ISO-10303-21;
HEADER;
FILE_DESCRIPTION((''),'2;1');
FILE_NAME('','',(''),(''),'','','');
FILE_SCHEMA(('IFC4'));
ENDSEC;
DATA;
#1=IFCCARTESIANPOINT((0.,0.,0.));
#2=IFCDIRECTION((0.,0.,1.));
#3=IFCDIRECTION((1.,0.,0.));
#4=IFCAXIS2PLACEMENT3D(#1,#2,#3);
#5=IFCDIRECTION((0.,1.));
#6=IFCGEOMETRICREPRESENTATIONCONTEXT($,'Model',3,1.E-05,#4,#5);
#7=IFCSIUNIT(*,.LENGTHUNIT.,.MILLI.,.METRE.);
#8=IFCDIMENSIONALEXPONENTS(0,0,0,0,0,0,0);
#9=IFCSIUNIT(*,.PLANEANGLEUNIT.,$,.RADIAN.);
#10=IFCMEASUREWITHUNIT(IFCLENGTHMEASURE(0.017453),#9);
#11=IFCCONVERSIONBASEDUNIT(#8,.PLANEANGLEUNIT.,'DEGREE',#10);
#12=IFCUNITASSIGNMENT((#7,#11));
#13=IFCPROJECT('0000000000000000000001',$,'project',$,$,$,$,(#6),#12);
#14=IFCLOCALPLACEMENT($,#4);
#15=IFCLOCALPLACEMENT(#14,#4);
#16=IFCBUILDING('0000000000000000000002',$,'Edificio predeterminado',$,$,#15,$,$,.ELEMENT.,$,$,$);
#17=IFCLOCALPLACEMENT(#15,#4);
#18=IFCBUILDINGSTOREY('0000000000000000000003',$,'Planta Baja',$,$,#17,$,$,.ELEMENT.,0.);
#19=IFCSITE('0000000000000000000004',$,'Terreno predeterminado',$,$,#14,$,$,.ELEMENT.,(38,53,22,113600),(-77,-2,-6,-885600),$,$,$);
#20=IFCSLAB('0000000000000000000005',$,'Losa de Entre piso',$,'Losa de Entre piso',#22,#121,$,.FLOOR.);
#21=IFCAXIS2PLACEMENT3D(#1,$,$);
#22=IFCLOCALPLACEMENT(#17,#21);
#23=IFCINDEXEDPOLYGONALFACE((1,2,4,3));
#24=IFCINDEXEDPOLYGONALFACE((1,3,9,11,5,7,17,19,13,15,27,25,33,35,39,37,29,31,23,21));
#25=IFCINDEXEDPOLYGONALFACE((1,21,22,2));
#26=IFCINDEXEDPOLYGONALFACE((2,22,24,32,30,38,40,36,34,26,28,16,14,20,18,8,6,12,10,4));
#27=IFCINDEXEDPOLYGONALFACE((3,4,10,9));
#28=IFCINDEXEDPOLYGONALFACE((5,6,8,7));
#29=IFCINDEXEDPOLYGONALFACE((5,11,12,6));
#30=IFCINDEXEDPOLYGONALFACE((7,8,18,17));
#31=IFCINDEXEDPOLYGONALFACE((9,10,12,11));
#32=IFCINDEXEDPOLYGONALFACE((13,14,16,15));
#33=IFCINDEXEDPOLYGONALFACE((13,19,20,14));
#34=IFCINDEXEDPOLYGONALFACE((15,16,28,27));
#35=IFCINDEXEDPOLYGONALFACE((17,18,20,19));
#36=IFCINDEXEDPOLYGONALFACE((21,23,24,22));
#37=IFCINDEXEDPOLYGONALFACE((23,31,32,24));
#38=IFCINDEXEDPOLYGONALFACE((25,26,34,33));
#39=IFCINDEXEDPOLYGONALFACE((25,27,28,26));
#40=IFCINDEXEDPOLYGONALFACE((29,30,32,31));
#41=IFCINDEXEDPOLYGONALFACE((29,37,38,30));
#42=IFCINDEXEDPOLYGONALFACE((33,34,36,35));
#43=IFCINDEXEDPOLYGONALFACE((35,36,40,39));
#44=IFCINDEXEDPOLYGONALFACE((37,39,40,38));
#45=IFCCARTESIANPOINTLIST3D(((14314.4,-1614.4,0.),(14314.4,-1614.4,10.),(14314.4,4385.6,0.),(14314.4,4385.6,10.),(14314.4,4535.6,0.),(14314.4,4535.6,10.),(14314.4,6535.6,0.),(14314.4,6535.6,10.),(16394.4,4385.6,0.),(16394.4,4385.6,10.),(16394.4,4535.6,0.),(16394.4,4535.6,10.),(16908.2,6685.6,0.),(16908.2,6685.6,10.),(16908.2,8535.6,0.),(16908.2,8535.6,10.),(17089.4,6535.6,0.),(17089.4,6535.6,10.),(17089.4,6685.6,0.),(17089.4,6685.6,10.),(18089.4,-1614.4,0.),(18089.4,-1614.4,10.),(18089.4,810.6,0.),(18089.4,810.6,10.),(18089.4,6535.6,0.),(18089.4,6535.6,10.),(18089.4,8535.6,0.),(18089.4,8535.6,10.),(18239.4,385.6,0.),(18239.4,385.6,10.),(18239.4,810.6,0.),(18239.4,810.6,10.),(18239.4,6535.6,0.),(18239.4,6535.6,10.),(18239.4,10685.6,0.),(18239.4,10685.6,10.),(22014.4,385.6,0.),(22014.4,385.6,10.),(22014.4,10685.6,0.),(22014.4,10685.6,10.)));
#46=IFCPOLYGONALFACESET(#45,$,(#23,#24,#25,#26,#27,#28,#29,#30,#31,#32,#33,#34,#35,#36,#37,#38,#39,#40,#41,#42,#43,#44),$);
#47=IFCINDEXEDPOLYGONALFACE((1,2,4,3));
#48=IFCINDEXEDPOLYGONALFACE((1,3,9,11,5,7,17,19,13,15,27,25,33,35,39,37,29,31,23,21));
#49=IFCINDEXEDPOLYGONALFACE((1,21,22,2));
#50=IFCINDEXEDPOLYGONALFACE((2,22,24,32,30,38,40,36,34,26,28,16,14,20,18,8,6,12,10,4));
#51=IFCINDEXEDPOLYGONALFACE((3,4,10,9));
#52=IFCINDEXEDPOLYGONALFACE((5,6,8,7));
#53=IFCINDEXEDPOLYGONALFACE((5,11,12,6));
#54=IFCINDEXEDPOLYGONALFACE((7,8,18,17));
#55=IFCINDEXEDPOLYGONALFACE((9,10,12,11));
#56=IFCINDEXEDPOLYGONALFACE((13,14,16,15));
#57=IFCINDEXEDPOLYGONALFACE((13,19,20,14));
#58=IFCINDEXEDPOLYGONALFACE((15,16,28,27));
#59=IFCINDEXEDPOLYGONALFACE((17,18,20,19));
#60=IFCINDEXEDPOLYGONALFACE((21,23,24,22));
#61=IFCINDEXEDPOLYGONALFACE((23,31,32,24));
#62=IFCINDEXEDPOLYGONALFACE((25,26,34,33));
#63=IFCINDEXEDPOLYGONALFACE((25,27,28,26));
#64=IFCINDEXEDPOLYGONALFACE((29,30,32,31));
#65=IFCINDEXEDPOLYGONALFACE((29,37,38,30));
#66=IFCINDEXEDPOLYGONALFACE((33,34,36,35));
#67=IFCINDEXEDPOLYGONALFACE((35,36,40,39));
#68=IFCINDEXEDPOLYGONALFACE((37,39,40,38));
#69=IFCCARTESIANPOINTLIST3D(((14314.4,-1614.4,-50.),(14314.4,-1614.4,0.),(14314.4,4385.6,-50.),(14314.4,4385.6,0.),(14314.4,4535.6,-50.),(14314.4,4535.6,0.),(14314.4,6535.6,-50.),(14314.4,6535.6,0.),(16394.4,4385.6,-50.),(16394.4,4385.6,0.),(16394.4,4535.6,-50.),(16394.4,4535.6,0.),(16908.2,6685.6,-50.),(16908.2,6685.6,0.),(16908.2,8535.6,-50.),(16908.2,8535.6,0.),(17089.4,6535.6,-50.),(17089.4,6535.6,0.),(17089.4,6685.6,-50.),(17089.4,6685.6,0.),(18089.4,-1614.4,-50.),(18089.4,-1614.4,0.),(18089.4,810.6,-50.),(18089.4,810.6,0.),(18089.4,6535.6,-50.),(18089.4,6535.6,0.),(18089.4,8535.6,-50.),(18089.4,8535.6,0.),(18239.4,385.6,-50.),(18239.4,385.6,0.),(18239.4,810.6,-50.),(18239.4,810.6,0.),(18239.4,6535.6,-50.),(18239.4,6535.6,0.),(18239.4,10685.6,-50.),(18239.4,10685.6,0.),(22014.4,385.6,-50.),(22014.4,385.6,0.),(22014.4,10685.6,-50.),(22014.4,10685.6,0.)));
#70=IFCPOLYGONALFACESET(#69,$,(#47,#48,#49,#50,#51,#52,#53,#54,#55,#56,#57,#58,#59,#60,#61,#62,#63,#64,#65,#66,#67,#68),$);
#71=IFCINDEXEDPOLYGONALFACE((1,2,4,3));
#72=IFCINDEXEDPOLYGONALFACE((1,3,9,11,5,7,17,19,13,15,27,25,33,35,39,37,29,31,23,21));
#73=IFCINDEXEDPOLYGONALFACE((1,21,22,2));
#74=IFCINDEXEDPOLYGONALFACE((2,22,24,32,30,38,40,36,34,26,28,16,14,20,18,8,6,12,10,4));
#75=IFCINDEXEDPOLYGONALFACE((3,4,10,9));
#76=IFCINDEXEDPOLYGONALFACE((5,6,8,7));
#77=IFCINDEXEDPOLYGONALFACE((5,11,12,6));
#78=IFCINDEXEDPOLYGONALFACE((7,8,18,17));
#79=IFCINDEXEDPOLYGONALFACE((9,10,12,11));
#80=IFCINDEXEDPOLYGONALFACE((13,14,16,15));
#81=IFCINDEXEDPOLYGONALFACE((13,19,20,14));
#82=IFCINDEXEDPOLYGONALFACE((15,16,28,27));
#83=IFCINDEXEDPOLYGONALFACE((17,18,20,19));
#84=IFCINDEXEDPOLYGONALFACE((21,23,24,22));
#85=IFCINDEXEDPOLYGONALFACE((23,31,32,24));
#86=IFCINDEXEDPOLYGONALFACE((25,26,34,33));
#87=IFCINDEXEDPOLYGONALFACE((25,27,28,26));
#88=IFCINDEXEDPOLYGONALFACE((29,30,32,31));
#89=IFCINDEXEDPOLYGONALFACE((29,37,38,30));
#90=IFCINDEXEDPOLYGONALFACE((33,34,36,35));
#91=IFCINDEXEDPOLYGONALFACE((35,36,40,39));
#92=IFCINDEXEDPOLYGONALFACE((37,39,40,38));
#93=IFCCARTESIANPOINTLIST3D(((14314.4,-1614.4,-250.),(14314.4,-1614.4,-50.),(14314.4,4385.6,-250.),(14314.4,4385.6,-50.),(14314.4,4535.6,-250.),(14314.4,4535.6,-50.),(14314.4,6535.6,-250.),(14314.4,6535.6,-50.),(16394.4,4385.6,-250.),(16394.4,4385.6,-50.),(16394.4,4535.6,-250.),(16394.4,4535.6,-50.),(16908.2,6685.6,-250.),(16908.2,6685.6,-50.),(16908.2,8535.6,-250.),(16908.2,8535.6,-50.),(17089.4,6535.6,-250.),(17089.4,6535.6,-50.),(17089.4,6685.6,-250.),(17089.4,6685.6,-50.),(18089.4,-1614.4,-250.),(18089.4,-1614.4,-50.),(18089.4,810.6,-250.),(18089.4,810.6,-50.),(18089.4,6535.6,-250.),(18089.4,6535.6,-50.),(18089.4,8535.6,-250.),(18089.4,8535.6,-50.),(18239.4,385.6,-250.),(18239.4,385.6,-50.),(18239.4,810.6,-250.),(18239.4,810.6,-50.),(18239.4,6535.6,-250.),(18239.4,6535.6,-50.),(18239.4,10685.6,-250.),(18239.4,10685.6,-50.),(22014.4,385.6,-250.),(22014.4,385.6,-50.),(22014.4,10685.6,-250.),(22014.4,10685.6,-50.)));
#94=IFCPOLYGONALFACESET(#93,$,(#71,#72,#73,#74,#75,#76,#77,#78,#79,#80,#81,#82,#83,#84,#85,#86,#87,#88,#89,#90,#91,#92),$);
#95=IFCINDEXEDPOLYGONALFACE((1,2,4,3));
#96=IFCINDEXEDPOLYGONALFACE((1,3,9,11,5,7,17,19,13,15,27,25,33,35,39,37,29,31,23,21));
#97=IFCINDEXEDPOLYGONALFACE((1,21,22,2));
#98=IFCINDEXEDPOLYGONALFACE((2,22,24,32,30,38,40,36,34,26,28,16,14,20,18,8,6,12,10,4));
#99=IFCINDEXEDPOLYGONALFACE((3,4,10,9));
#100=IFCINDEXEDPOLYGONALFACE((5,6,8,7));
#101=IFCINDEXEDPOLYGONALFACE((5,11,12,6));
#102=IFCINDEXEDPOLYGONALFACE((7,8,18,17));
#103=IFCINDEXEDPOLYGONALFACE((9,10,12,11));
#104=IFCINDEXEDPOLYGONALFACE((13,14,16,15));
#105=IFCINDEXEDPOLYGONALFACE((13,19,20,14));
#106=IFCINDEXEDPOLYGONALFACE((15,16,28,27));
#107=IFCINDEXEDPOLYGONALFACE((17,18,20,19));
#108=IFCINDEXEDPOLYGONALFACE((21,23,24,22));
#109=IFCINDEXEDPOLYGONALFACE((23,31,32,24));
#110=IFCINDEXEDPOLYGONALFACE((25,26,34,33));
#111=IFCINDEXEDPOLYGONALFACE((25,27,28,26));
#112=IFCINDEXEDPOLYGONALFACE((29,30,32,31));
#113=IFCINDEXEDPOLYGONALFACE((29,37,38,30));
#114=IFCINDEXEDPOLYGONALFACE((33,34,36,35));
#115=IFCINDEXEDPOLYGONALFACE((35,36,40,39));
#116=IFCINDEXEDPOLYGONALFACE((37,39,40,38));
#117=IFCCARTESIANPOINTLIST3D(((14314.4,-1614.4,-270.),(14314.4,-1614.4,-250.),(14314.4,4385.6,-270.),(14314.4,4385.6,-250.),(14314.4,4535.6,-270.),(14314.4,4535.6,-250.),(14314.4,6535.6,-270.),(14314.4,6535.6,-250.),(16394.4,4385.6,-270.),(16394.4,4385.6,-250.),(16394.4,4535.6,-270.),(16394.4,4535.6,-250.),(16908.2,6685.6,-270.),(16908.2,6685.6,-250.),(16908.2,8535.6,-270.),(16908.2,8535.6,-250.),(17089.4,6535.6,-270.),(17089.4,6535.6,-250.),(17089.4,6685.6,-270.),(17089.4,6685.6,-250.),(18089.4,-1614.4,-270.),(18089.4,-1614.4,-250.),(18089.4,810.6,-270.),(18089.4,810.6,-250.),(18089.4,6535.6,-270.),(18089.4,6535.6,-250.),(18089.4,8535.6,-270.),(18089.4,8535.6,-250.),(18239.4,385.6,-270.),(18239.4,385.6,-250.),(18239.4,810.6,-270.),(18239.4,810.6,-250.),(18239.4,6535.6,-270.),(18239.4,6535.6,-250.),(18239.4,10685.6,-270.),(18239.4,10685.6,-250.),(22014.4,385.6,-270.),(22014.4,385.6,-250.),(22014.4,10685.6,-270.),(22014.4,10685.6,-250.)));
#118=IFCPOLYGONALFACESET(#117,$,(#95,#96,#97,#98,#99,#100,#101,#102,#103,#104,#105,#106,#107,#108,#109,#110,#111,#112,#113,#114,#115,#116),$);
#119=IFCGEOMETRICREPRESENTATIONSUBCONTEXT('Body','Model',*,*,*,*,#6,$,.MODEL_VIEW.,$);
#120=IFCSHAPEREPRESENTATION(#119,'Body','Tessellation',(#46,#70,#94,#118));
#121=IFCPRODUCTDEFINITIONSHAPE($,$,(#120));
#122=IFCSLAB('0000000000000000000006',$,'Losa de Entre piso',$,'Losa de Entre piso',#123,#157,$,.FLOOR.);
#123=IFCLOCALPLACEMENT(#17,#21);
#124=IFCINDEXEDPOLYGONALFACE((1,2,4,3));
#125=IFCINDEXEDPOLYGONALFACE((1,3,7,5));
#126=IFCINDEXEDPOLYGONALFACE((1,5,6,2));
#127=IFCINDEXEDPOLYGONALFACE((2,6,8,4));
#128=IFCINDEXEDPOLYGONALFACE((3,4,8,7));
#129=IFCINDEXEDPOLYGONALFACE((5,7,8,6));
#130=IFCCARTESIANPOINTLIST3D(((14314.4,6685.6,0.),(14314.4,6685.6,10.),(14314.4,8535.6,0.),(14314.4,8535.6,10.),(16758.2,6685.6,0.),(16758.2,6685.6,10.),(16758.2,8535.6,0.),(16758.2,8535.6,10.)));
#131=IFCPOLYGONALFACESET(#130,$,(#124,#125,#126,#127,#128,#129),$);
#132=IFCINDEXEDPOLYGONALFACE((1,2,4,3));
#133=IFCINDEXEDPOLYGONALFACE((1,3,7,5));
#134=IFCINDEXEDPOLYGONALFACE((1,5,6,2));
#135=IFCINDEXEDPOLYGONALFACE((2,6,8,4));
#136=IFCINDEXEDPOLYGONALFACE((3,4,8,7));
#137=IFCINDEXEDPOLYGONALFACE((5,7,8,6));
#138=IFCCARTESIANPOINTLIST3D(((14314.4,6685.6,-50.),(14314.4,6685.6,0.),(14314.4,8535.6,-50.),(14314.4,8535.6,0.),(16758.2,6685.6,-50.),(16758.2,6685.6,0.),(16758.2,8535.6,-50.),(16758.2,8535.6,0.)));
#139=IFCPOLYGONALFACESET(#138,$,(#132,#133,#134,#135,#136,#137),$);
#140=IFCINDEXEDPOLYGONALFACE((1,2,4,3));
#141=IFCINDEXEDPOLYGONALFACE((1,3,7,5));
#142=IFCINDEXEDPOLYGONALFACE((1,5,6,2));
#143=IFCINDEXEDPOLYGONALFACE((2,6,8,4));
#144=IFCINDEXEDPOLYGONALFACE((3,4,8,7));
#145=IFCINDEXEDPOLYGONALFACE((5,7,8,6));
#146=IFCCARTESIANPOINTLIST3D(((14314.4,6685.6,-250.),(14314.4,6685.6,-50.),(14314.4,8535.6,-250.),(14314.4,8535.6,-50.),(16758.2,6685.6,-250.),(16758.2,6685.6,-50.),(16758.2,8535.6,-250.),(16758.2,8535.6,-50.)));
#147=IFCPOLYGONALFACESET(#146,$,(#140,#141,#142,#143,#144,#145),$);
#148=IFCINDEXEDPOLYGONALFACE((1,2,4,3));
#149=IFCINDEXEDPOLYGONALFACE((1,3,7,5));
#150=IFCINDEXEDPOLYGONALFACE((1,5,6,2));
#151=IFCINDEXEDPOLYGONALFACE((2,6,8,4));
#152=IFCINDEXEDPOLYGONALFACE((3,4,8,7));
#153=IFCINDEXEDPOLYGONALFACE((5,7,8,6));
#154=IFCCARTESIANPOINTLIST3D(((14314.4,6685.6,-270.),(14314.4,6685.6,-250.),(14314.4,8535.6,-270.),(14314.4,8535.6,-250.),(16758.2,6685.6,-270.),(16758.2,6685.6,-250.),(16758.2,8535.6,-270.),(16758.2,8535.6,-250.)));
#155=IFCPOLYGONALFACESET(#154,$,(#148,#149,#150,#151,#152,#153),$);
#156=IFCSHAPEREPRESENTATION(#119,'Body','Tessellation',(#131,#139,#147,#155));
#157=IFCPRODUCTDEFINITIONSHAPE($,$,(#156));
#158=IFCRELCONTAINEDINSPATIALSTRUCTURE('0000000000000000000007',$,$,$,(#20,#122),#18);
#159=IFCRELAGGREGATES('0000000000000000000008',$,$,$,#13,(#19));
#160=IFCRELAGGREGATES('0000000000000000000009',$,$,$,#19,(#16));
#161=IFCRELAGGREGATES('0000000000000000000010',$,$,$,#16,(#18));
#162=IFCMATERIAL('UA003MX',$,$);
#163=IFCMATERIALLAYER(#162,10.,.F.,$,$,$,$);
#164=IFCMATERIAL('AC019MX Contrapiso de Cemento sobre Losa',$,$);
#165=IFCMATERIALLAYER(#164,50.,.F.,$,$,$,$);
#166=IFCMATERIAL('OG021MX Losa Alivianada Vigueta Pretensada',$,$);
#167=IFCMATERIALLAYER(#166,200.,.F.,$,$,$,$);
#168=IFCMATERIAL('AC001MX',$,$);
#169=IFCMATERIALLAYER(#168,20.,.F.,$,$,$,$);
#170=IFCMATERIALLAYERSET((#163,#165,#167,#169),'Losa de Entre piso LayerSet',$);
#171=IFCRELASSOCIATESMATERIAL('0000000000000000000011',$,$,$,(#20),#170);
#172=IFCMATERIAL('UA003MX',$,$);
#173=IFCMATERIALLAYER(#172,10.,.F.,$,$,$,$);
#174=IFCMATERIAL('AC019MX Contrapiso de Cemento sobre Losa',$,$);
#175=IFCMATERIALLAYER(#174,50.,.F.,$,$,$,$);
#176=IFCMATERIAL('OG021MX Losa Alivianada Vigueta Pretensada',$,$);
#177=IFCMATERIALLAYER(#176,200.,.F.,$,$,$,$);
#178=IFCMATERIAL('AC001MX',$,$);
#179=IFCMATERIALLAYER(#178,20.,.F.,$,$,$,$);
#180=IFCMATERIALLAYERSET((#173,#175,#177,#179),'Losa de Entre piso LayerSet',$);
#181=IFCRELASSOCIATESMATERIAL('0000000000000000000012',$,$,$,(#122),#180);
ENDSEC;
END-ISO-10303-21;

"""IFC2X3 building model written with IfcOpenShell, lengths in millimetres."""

from ifc_helpers import new_model, entity, si_unit, converted_unit, direction, frame, origin_with_axes, place, context, subcontext, project, spatial, polyline, outline, extrude, material, layer, layer_set, layer_usage, element, save


model = new_model("IFC2X3")

# Units and contexts
model_context = context("Model", 3, precision=1e-05, world=origin_with_axes(), true_north=direction((0.0, 1.0)))
body_context = subcontext(model_context, "Body", "Model", "MODEL_VIEW")
ifc_project = project(units=[si_unit("LENGTHUNIT", "METRE", prefix="MILLI"), converted_unit("PLANEANGLEUNIT", "DEGREE", entity("IfcLengthMeasure", 0.017453), si_unit("PLANEANGLEUNIT", "RADIAN"), dimensions=[0, 0, 0, 0, 0, 0, 0])], contexts=[model_context])

# Site, building, storey
site_placement = place(None, origin_with_axes())
site = spatial("IfcSite", under=ifc_project, at=site_placement, Name="Terreno predeterminado", CompositionType="ELEMENT", RefLatitude=(38, 53, 22, 113600), RefLongitude=(-77, -2, -6, -885600))
building_placement = place(site_placement, origin_with_axes())
building = spatial("IfcBuilding", under=site, at=building_placement, Name="Edificio predeterminado", CompositionType="ELEMENT")
storey_placement = place(building_placement, origin_with_axes())
storey = spatial("IfcBuildingStorey", under=building, at=storey_placement, Name="Planta Baja", CompositionType="ELEMENT", Elevation=0.0)

# Slabs
ifc_material_1 = material(Name="UA003MX")
ifc_layer_1 = layer(ifc_material_1, 10.0, ventilated=False)
ifc_material_2 = material(Name="AC019MX Contrapiso de Cemento sobre Losa")
ifc_layer_2 = layer(ifc_material_2, 50.0, ventilated=False)
ifc_material_3 = material(Name="OG021MX Losa Alivianada Vigueta Pretensada")
ifc_layer_3 = layer(ifc_material_3, 200.0, ventilated=False)
ifc_material_4 = material(Name="AC001MX")
ifc_layer_4 = layer(ifc_material_4, 20.0, ventilated=False)
ifc_layer_set_1 = layer_set([ifc_layer_1, ifc_layer_2, ifc_layer_3, ifc_layer_4], Name="Losa de Entre piso LayerSet")
ifc_layer_usage_1 = layer_usage(ifc_layer_set_1, "AXIS3", "POSITIVE", 0.0)
slab_1_placement = place(storey_placement, origin_with_axes())
element("IfcSlab", 1, at=slab_1_placement, inside=storey, material=ifc_layer_usage_1, Name="Losa de Entre piso", ObjectType="Losa de Entre piso", PredefinedType="FLOOR", context=body_context, shape_type="SweptSolid", body=[
    extrude(outline(polyline([(0.0, -6000.0), (3775.0, -6000.0), (3775.0, -3575.0), (3925.0, -3575.0), (3925.0, -4000.0), (7700.0, -4000.0), (7700.0, 6300.0), (3925.0, 6300.0), (3925.0, 2150.0), (3775.0, 2150.0), (3775.0, 4150.0), (2593.9, 4150.0), (2593.9, 2300.0), (2775.0, 2300.0), (2775.0, 2150.0), (0.0, 2150.0), (0.0, 150.0), (2080.0, 150.0), (2080.0, 0.0), (0.0, 0.0), (0.0, -6000.0)])), frame((14314.4, 4385.6, 0.0), z_axis=(0.0, 0.0, 1.0), x_axis=(1.0, 0.0, 0.0)), (0.0, 0.0, 1.0), 10.0),
    extrude(outline(polyline([(0.0, -6000.0), (3775.0, -6000.0), (3775.0, -3575.0), (3925.0, -3575.0), (3925.0, -4000.0), (7700.0, -4000.0), (7700.0, 6300.0), (3925.0, 6300.0), (3925.0, 2150.0), (3775.0, 2150.0), (3775.0, 4150.0), (2593.9, 4150.0), (2593.9, 2300.0), (2775.0, 2300.0), (2775.0, 2150.0), (0.0, 2150.0), (0.0, 150.0), (2080.0, 150.0), (2080.0, 0.0), (0.0, 0.0), (0.0, -6000.0)])), frame((14314.4, 4385.6, -50.0), z_axis=(0.0, 0.0, 1.0), x_axis=(1.0, 0.0, 0.0)), (0.0, 0.0, 1.0), 50.0),
    extrude(outline(polyline([(0.0, -6000.0), (3775.0, -6000.0), (3775.0, -3575.0), (3925.0, -3575.0), (3925.0, -4000.0), (7700.0, -4000.0), (7700.0, 6300.0), (3925.0, 6300.0), (3925.0, 2150.0), (3775.0, 2150.0), (3775.0, 4150.0), (2593.9, 4150.0), (2593.9, 2300.0), (2775.0, 2300.0), (2775.0, 2150.0), (0.0, 2150.0), (0.0, 150.0), (2080.0, 150.0), (2080.0, 0.0), (0.0, 0.0), (0.0, -6000.0)])), frame((14314.4, 4385.6, -250.0), z_axis=(0.0, 0.0, 1.0), x_axis=(1.0, 0.0, 0.0)), (0.0, 0.0, 1.0), 200.0),
    extrude(outline(polyline([(0.0, -6000.0), (3775.0, -6000.0), (3775.0, -3575.0), (3925.0, -3575.0), (3925.0, -4000.0), (7700.0, -4000.0), (7700.0, 6300.0), (3925.0, 6300.0), (3925.0, 2150.0), (3775.0, 2150.0), (3775.0, 4150.0), (2593.9, 4150.0), (2593.9, 2300.0), (2775.0, 2300.0), (2775.0, 2150.0), (0.0, 2150.0), (0.0, 150.0), (2080.0, 150.0), (2080.0, 0.0), (0.0, 0.0), (0.0, -6000.0)])), frame((14314.4, 4385.6, -270.0), z_axis=(0.0, 0.0, 1.0), x_axis=(1.0, 0.0, 0.0)), (0.0, 0.0, 1.0), 20.0),
])
ifc_material_5 = material(Name="UA003MX")
ifc_layer_5 = layer(ifc_material_5, 10.0, ventilated=False)
ifc_material_6 = material(Name="AC019MX Contrapiso de Cemento sobre Losa")
ifc_layer_6 = layer(ifc_material_6, 50.0, ventilated=False)
ifc_material_7 = material(Name="OG021MX Losa Alivianada Vigueta Pretensada")
ifc_layer_7 = layer(ifc_material_7, 200.0, ventilated=False)
ifc_material_8 = material(Name="AC001MX")
ifc_layer_8 = layer(ifc_material_8, 20.0, ventilated=False)
ifc_layer_set_2 = layer_set([ifc_layer_5, ifc_layer_6, ifc_layer_7, ifc_layer_8], Name="Losa de Entre piso LayerSet")
ifc_layer_usage_2 = layer_usage(ifc_layer_set_2, "AXIS3", "NEGATIVE", 0.0)
slab_2_placement = place(storey_placement, origin_with_axes())
element("IfcSlab", 2, at=slab_2_placement, inside=storey, material=ifc_layer_usage_2, Name="Losa de Entre piso", ObjectType="Losa de Entre piso", PredefinedType="FLOOR", context=body_context, shape_type="SweptSolid", body=[
    extrude(outline(polyline([(0.0, 2443.9), (1850.0, 2443.9), (1850.0, 0.0), (0.0, 0.0), (0.0, 2443.9)])), frame((14314.4, 6685.6, 0.0), z_axis=(0.0, 0.0, -1.0), x_axis=(0.0, 1.0, 0.0)), (0.0, 0.0, -1.0), 10.0),
    extrude(outline(polyline([(0.0, 2443.9), (1850.0, 2443.9), (1850.0, 0.0), (0.0, 0.0), (0.0, 2443.9)])), frame((14314.4, 6685.6, -50.0), z_axis=(0.0, 0.0, -1.0), x_axis=(0.0, 1.0, 0.0)), (0.0, 0.0, -1.0), 50.0),
    extrude(outline(polyline([(0.0, 2443.9), (1850.0, 2443.9), (1850.0, 0.0), (0.0, 0.0), (0.0, 2443.9)])), frame((14314.4, 6685.6, -250.0), z_axis=(0.0, 0.0, -1.0), x_axis=(0.0, 1.0, 0.0)), (0.0, 0.0, -1.0), 200.0),
    extrude(outline(polyline([(0.0, 2443.9), (1850.0, 2443.9), (1850.0, 0.0), (0.0, 0.0), (0.0, 2443.9)])), frame((14314.4, 6685.6, -270.0), z_axis=(0.0, 0.0, -1.0), x_axis=(0.0, 1.0, 0.0)), (0.0, 0.0, -1.0), 20.0),
])

save(model, "model.ifc")
